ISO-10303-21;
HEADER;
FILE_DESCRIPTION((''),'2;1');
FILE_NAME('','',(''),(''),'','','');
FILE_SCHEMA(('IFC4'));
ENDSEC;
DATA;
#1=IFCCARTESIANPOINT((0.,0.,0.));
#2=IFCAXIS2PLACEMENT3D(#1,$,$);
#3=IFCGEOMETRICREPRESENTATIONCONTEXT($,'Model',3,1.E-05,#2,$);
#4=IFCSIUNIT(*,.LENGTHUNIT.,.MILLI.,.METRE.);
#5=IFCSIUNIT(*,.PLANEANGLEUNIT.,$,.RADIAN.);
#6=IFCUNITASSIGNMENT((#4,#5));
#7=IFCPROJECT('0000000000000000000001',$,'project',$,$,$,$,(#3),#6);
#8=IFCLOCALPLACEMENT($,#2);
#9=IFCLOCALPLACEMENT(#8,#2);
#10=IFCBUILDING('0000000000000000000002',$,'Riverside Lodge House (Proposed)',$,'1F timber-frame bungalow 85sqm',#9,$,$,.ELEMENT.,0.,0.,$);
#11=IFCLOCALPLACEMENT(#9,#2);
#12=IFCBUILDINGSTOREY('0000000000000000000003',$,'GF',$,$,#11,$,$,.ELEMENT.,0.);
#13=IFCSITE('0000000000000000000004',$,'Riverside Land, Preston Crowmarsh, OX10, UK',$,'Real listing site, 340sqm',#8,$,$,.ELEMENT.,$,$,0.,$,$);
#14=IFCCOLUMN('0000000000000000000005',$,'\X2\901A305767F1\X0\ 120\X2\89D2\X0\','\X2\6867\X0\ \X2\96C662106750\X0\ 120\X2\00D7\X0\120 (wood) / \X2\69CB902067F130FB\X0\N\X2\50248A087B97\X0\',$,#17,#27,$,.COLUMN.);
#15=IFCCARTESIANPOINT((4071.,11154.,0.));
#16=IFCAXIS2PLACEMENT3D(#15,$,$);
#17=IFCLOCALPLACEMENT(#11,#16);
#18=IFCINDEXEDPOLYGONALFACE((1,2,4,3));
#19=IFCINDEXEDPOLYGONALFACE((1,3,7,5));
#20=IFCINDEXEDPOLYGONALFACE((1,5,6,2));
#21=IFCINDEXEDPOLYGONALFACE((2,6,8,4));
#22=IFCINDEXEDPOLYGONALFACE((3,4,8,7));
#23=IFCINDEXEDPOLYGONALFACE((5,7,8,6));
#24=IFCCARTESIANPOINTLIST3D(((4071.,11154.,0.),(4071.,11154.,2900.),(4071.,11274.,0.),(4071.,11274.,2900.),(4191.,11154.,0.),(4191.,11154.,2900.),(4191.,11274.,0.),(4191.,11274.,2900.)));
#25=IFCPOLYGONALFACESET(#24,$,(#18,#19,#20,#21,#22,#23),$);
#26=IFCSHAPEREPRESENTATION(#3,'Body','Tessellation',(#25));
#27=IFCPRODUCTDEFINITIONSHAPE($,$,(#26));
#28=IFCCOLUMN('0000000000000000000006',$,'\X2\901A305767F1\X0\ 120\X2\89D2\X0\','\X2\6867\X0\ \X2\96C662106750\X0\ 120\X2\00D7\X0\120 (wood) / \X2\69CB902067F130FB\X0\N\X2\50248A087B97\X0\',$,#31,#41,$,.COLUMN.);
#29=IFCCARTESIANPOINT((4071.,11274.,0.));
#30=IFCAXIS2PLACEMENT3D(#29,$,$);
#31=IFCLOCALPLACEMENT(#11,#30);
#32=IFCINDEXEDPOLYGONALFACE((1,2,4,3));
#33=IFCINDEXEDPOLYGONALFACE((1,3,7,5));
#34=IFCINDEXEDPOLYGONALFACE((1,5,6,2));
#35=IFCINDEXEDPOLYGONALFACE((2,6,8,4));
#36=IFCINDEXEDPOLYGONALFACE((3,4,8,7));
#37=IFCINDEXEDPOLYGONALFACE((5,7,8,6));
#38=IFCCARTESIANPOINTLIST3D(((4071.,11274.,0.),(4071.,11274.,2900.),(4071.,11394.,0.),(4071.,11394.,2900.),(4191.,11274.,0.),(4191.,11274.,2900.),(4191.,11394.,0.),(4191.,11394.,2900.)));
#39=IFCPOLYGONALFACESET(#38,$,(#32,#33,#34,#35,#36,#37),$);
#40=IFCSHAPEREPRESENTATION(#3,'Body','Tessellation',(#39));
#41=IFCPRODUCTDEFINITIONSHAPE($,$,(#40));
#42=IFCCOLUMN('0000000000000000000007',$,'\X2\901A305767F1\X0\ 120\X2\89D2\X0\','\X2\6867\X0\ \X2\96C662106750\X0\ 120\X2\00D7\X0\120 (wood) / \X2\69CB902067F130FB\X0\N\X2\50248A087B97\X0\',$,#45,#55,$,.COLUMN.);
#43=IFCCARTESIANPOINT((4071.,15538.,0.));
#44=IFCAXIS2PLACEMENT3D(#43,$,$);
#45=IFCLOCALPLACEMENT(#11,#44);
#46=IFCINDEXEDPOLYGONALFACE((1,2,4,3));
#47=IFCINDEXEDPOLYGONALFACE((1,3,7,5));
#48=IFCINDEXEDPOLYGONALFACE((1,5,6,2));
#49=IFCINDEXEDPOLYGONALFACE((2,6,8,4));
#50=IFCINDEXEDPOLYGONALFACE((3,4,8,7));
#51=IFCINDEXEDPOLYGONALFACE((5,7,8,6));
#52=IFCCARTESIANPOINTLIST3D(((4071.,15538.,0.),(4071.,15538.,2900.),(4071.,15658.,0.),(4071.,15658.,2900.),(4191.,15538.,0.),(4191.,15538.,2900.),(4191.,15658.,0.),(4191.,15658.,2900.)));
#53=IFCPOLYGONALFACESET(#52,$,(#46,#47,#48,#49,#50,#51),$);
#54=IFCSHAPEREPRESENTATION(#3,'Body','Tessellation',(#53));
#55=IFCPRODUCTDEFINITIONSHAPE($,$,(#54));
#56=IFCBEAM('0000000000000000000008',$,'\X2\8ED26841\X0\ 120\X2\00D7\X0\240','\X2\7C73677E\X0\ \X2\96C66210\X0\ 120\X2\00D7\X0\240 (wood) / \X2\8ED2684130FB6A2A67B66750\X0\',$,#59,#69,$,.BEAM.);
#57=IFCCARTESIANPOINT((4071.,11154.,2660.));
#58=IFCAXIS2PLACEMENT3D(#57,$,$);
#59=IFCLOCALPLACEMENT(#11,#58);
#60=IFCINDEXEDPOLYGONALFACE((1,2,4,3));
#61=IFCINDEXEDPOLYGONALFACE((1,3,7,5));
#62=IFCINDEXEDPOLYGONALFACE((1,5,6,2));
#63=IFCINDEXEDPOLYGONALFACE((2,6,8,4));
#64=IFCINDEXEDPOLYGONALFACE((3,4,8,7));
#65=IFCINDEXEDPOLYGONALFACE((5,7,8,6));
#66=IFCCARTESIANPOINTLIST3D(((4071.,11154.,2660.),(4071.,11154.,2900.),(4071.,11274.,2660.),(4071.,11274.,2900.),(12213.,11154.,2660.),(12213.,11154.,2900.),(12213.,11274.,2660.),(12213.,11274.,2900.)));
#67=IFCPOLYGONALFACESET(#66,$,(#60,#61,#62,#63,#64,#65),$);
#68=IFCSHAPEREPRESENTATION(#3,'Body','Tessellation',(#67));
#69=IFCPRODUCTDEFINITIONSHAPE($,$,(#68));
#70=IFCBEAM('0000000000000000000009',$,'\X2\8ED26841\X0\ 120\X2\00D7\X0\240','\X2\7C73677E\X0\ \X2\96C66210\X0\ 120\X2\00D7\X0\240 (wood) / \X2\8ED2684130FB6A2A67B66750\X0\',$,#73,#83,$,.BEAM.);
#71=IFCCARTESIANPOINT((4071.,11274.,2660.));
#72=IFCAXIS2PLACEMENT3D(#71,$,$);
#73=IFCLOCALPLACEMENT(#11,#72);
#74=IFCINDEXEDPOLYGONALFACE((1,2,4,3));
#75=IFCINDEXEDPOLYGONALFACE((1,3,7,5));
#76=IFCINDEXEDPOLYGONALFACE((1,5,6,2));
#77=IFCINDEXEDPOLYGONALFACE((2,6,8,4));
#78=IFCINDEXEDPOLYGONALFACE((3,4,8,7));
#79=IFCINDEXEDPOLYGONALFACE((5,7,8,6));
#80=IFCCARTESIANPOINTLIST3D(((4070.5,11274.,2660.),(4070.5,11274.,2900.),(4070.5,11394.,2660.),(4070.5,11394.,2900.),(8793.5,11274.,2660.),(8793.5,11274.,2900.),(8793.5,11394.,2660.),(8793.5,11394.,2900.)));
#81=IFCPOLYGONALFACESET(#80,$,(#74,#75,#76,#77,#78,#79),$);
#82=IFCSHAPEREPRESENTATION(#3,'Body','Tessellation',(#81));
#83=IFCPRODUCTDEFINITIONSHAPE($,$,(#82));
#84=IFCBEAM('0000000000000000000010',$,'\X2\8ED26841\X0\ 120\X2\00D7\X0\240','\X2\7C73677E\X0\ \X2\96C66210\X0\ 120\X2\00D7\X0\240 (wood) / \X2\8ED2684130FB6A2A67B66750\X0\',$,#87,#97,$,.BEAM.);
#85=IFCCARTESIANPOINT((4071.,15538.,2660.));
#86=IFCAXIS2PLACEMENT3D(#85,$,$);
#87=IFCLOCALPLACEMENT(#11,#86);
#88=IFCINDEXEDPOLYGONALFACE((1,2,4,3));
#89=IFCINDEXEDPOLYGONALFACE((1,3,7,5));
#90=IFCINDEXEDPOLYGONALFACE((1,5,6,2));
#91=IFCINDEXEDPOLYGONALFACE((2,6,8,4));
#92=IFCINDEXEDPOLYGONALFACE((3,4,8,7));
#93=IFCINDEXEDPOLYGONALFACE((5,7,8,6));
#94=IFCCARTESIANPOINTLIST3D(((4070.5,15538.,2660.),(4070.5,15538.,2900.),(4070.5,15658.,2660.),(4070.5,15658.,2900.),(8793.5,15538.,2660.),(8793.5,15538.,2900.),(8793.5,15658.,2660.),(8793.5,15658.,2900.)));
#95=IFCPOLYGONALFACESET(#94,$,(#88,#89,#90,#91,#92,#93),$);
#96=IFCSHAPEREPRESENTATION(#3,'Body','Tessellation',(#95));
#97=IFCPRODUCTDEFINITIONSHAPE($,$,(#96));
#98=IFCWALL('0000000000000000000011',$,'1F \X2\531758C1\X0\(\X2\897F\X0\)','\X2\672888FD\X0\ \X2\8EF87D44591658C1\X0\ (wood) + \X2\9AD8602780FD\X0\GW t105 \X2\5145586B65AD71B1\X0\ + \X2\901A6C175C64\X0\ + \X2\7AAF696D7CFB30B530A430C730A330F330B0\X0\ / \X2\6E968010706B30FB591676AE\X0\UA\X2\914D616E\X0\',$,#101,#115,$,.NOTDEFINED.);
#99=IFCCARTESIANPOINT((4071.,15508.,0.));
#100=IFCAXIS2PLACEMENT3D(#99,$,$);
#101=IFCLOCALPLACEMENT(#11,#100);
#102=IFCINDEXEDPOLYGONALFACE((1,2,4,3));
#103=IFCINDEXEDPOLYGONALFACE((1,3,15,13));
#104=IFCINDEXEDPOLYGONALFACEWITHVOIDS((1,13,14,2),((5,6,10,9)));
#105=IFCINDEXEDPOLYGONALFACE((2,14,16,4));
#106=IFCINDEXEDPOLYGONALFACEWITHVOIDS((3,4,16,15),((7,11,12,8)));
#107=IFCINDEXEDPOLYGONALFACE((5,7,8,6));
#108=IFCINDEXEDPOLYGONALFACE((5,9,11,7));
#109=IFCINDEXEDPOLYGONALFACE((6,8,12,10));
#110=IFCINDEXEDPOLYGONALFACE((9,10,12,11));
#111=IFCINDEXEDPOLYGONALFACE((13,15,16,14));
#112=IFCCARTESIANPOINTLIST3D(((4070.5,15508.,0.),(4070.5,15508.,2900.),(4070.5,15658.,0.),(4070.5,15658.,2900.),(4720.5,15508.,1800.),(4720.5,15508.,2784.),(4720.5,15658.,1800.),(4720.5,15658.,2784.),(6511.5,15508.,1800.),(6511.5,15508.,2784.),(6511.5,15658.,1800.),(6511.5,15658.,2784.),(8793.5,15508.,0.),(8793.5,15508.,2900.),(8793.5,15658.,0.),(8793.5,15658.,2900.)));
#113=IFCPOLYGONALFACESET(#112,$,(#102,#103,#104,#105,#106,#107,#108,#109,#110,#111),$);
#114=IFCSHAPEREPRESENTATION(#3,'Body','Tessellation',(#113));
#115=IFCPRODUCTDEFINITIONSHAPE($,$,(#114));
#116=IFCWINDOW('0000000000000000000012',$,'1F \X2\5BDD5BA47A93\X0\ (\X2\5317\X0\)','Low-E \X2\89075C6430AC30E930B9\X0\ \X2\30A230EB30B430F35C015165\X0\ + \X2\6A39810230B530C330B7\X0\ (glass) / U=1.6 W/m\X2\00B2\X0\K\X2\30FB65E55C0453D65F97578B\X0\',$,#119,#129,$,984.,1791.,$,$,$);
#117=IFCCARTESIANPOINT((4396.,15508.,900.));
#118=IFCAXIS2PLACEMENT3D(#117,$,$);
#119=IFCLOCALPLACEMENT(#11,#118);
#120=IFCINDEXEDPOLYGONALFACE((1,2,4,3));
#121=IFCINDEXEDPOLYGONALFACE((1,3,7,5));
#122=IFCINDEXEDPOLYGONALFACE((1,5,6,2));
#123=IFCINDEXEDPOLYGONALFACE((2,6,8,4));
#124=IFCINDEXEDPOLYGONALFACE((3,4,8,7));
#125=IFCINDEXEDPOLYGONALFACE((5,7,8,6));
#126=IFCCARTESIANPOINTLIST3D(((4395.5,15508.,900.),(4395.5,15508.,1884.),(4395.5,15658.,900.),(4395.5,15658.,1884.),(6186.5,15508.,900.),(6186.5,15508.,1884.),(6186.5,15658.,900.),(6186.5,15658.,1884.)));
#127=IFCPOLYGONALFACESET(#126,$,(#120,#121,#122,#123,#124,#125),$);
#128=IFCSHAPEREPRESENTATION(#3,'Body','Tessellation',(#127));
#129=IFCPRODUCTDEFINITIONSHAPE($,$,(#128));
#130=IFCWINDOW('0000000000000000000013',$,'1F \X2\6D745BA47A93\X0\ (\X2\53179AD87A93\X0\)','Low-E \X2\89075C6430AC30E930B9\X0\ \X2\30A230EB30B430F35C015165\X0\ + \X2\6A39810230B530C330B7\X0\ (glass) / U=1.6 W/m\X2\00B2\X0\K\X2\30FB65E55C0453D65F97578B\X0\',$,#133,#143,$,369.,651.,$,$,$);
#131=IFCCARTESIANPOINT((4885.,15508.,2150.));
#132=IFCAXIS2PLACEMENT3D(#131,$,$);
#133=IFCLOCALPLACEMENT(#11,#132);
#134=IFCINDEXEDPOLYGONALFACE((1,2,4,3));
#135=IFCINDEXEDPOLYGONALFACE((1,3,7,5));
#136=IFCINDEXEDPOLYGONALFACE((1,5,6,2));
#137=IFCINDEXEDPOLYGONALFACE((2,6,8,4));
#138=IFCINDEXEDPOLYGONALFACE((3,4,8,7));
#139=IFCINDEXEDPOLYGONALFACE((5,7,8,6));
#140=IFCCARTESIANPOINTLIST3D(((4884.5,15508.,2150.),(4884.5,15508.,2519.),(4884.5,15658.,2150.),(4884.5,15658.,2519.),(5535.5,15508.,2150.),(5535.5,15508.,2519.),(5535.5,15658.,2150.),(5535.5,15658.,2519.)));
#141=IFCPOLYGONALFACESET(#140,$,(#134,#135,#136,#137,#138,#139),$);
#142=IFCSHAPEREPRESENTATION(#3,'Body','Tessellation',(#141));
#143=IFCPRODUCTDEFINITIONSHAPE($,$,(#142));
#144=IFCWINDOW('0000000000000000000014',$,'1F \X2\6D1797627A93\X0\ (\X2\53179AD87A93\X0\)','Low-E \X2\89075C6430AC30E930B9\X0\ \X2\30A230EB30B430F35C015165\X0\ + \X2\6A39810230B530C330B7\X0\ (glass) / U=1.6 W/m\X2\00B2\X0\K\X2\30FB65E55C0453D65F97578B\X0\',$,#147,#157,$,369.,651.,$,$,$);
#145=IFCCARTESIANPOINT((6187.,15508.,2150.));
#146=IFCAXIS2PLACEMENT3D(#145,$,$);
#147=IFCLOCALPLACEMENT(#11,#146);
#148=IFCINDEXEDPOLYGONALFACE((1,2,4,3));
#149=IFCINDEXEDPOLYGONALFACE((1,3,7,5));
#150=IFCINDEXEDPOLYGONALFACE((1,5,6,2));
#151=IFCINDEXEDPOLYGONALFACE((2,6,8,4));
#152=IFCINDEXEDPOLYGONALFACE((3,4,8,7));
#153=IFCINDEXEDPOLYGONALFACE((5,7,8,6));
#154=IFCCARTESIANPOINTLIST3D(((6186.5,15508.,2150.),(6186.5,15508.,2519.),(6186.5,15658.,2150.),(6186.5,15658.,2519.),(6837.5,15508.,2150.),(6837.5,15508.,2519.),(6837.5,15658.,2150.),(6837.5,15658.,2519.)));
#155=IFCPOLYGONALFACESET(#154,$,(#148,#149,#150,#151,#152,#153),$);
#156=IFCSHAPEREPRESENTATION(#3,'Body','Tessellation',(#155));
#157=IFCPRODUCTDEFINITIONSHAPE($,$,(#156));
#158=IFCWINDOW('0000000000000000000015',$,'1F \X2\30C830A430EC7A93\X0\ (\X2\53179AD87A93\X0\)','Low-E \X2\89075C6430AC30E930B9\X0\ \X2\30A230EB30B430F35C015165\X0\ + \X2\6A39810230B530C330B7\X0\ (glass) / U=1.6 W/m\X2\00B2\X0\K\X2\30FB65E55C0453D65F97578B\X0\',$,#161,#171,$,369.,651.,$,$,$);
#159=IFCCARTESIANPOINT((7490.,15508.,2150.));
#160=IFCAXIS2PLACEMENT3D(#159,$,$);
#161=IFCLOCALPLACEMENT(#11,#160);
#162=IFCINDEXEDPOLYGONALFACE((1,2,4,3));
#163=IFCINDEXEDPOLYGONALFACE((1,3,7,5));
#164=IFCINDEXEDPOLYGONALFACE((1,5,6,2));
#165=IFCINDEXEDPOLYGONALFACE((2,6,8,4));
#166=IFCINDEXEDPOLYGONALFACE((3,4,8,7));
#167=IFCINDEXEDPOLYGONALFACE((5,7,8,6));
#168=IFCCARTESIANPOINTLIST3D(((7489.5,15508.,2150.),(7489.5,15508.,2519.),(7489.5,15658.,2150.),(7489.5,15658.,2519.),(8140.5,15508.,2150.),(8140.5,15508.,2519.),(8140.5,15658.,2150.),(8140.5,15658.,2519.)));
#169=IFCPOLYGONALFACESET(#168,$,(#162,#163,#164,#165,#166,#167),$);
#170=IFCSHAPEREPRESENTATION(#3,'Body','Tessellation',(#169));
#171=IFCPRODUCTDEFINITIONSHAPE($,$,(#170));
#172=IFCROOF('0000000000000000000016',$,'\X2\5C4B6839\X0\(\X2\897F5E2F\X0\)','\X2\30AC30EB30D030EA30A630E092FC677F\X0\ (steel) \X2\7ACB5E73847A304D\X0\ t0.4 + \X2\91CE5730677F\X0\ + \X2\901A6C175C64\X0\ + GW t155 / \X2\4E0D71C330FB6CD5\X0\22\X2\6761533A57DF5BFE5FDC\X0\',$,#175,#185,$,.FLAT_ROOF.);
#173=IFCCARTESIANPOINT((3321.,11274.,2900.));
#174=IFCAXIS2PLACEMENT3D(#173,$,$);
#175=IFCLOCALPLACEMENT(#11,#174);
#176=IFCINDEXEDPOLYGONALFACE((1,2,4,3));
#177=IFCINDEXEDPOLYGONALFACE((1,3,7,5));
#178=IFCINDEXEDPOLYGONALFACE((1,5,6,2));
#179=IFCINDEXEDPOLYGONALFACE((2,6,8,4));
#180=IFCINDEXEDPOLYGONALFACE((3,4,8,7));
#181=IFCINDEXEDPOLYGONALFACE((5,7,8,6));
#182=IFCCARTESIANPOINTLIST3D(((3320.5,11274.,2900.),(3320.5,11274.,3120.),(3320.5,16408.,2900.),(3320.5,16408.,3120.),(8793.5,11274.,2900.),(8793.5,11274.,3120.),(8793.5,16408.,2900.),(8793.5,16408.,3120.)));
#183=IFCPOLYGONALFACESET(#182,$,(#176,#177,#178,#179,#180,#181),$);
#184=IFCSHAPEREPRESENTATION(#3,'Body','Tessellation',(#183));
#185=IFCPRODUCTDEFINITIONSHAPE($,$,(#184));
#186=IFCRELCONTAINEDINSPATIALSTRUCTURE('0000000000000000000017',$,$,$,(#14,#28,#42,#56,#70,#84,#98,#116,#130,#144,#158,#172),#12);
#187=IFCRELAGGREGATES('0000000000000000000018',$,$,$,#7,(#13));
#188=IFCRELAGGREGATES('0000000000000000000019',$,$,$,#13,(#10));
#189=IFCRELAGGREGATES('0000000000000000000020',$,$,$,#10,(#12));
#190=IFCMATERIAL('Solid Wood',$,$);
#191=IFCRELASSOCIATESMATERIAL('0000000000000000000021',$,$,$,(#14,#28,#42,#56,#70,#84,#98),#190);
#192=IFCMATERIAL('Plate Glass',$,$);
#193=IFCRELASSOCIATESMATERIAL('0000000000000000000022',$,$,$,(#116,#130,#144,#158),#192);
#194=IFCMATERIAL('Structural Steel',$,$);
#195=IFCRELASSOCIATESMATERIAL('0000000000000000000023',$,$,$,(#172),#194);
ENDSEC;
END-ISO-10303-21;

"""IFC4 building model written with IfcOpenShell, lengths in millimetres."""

from ifc_helpers import new_model, si_unit, frame, frame_2d, origin, place, context, project, spatial, rectangle, extrude, material, element, fill, save


model = new_model("IFC4")

# Units and contexts
model_context = context("Model", 3, precision=1e-05, world=origin())
ifc_project = project(units=[si_unit("LENGTHUNIT", "METRE", prefix="MILLI"), si_unit("PLANEANGLEUNIT", "RADIAN")], contexts=[model_context])

# Site, building, storey
site_placement = place(None, origin())
site = spatial("IfcSite", under=ifc_project, at=site_placement, Name="Riverside Land, Preston Crowmarsh, OX10, UK", ObjectType="Real listing site, 340sqm", CompositionType="ELEMENT", RefElevation=0.0)
building_placement = place(site_placement, origin())
building = spatial("IfcBuilding", under=site, at=building_placement, Name="Riverside Lodge House (Proposed)", ObjectType="1F timber-frame bungalow 85sqm", CompositionType="ELEMENT", ElevationOfRefHeight=0.0, ElevationOfTerrain=0.0)
storey_placement = place(building_placement, origin())
storey = spatial("IfcBuildingStorey", under=building, at=storey_placement, Name="GF", CompositionType="ELEMENT", Elevation=0.0)

# Columns
ifc_material_1 = material(Name="Solid Wood")
column_1_placement = place(storey_placement, frame((4071.0, 11154.0, 0.0)))
element("IfcColumn", 1, at=column_1_placement, inside=storey, material=ifc_material_1, Name="通し柱 120角", Description="桧 集成材 120×120 (wood) / 構造柱・N値計算", PredefinedType="COLUMN", context=model_context, shape_type="SweptSolid", body=[
    extrude(rectangle(XDim=120.0, YDim=120.0, at=frame_2d((60.0, 60.0))), frame((4071.0, 11154.0, 0.0)), (0.0, 0.0, 1.0), 2900.0),
])
column_2_placement = place(storey_placement, frame((4071.0, 11274.0, 0.0)))
element("IfcColumn", 2, at=column_2_placement, inside=storey, material=ifc_material_1, Name="通し柱 120角", Description="桧 集成材 120×120 (wood) / 構造柱・N値計算", PredefinedType="COLUMN", context=model_context, shape_type="SweptSolid", body=[
    extrude(rectangle(XDim=120.0, YDim=120.0, at=frame_2d((60.0, 60.0))), frame((4071.0, 11274.0, 0.0)), (0.0, 0.0, 1.0), 2900.0),
])
column_3_placement = place(storey_placement, frame((4071.0, 15538.0, 0.0)))
element("IfcColumn", 3, at=column_3_placement, inside=storey, material=ifc_material_1, Name="通し柱 120角", Description="桧 集成材 120×120 (wood) / 構造柱・N値計算", PredefinedType="COLUMN", context=model_context, shape_type="SweptSolid", body=[
    extrude(rectangle(XDim=120.0, YDim=120.0, at=frame_2d((60.0, 60.0))), frame((4071.0, 15538.0, 0.0)), (0.0, 0.0, 1.0), 2900.0),
])

# Beams
beam_1_placement = place(storey_placement, frame((4071.0, 11154.0, 2660.0)))
element("IfcBeam", 4, at=beam_1_placement, inside=storey, material=ifc_material_1, Name="軒桁 120×240", Description="米松 集成 120×240 (wood) / 軒桁・横架材", PredefinedType="BEAM", context=model_context, shape_type="SweptSolid", body=[
    extrude(rectangle(XDim=8142.0, YDim=120.0, at=frame_2d((4071.0, 60.0))), frame((4071.0, 11154.0, 2660.0)), (0.0, 0.0, 1.0), 240.0),
])
beam_2_placement = place(storey_placement, frame((4071.0, 11274.0, 2660.0)))
element("IfcBeam", 5, at=beam_2_placement, inside=storey, material=ifc_material_1, Name="軒桁 120×240", Description="米松 集成 120×240 (wood) / 軒桁・横架材", PredefinedType="BEAM", context=model_context, shape_type="SweptSolid", body=[
    extrude(rectangle(XDim=4723.0, YDim=120.0, at=frame_2d((2361.0, 60.0))), frame((4071.0, 11274.0, 2660.0)), (0.0, 0.0, 1.0), 240.0),
])
beam_3_placement = place(storey_placement, frame((4071.0, 15538.0, 2660.0)))
element("IfcBeam", 6, at=beam_3_placement, inside=storey, material=ifc_material_1, Name="軒桁 120×240", Description="米松 集成 120×240 (wood) / 軒桁・横架材", PredefinedType="BEAM", context=model_context, shape_type="SweptSolid", body=[
    extrude(rectangle(XDim=4723.0, YDim=120.0, at=frame_2d((2361.0, 60.0))), frame((4071.0, 15538.0, 2660.0)), (0.0, 0.0, 1.0), 240.0),
])

# Wall, openings, windows
wall_1_placement = place(storey_placement, frame((4071.0, 15508.0, 0.0)))
wall_1 = element("IfcWall", 7, at=wall_1_placement, inside=storey, material=ifc_material_1, Name="1F 北壁(西)", Description="木製 軸組外壁 (wood) + 高性能GW t105 充填断熱 + 通気層 + 窯業系サイディング / 準耐火・外皮UA配慮", PredefinedType="NOTDEFINED", context=model_context, shape_type="SweptSolid", body=[
    extrude(rectangle(XDim=4723.0, YDim=150.0, at=frame_2d((2361.0, 75.0))), frame((4071.0, 15508.0, 0.0)), (0.0, 0.0, 1.0), 2900.0),
])
opening_1_placement = place(storey_placement, frame((4396.0, 15508.0, 900.0)))
opening_1 = element("IfcOpeningElement", 8, at=opening_1_placement, cuts=wall_1, PredefinedType="NOTDEFINED", context=model_context, shape_type="SweptSolid", body=[
    extrude(rectangle(XDim=1791.0, YDim=150.0, at=frame_2d((895.0, 75.0))), frame((4396.0, 15508.0, 900.0)), (0.0, 0.0, 1.0), 984.0),
])
opening_2_placement = place(storey_placement, frame((4885.0, 15508.0, 2150.0)))
opening_2 = element("IfcOpeningElement", 9, at=opening_2_placement, cuts=wall_1, PredefinedType="NOTDEFINED", context=model_context, shape_type="SweptSolid", body=[
    extrude(rectangle(XDim=651.0, YDim=150.0, at=frame_2d((325.0, 75.0))), frame((4885.0, 15508.0, 2150.0)), (0.0, 0.0, 1.0), 369.0),
])
opening_3_placement = place(storey_placement, frame((6187.0, 15508.0, 2150.0)))
opening_3 = element("IfcOpeningElement", 10, at=opening_3_placement, cuts=wall_1, PredefinedType="NOTDEFINED", context=model_context, shape_type="SweptSolid", body=[
    extrude(rectangle(XDim=651.0, YDim=150.0, at=frame_2d((325.0, 75.0))), frame((6187.0, 15508.0, 2150.0)), (0.0, 0.0, 1.0), 369.0),
])
opening_4_placement = place(storey_placement, frame((7490.0, 15508.0, 2150.0)))
opening_4 = element("IfcOpeningElement", 11, at=opening_4_placement, cuts=wall_1, PredefinedType="NOTDEFINED", context=model_context, shape_type="SweptSolid", body=[
    extrude(rectangle(XDim=651.0, YDim=150.0, at=frame_2d((325.0, 75.0))), frame((7490.0, 15508.0, 2150.0)), (0.0, 0.0, 1.0), 369.0),
])
ifc_material_2 = material(Name="Plate Glass")
window_1_placement = place(storey_placement, frame((4396.0, 15508.0, 900.0)))
window_1 = element("IfcWindow", 12, at=window_1_placement, inside=storey, material=ifc_material_2, Name="1F 寝室窓 (北)", Description="Low-E 複層ガラス アルゴン封入 + 樹脂サッシ (glass) / U=1.6 W/m²K・日射取得型", OverallHeight=984.0, OverallWidth=1791.0, context=model_context, shape_type="SweptSolid", body=[
    extrude(rectangle(XDim=1791.0, YDim=150.0, at=frame_2d((895.0, 75.0))), frame((4396.0, 15508.0, 900.0)), (0.0, 0.0, 1.0), 984.0),
])
fill(opening_1, window_1)
window_2_placement = place(storey_placement, frame((4885.0, 15508.0, 2150.0)))
window_2 = element("IfcWindow", 13, at=window_2_placement, inside=storey, material=ifc_material_2, Name="1F 浴室窓 (北高窓)", Description="Low-E 複層ガラス アルゴン封入 + 樹脂サッシ (glass) / U=1.6 W/m²K・日射取得型", OverallHeight=369.0, OverallWidth=651.0, context=model_context, shape_type="SweptSolid", body=[
    extrude(rectangle(XDim=651.0, YDim=150.0, at=frame_2d((325.0, 75.0))), frame((4885.0, 15508.0, 2150.0)), (0.0, 0.0, 1.0), 369.0),
])
fill(opening_2, window_2)
window_3_placement = place(storey_placement, frame((6187.0, 15508.0, 2150.0)))
window_3 = element("IfcWindow", 14, at=window_3_placement, inside=storey, material=ifc_material_2, Name="1F 洗面窓 (北高窓)", Description="Low-E 複層ガラス アルゴン封入 + 樹脂サッシ (glass) / U=1.6 W/m²K・日射取得型", OverallHeight=369.0, OverallWidth=651.0, context=model_context, shape_type="SweptSolid", body=[
    extrude(rectangle(XDim=651.0, YDim=150.0, at=frame_2d((325.0, 75.0))), frame((6187.0, 15508.0, 2150.0)), (0.0, 0.0, 1.0), 369.0),
])
fill(opening_3, window_3)
window_4_placement = place(storey_placement, frame((7490.0, 15508.0, 2150.0)))
window_4 = element("IfcWindow", 15, at=window_4_placement, inside=storey, material=ifc_material_2, Name="1F トイレ窓 (北高窓)", Description="Low-E 複層ガラス アルゴン封入 + 樹脂サッシ (glass) / U=1.6 W/m²K・日射取得型", OverallHeight=369.0, OverallWidth=651.0, context=model_context, shape_type="SweptSolid", body=[
    extrude(rectangle(XDim=651.0, YDim=150.0, at=frame_2d((325.0, 75.0))), frame((7490.0, 15508.0, 2150.0)), (0.0, 0.0, 1.0), 369.0),
])
fill(opening_4, window_4)

# Roof
ifc_material_3 = material(Name="Structural Steel")
roof_placement = place(storey_placement, frame((3321.0, 11274.0, 2900.0)))
element("IfcRoof", 16, at=roof_placement, inside=storey, material=ifc_material_3, Name="屋根(西帯)", Description="ガルバリウム鋼板 (steel) 立平葺き t0.4 + 野地板 + 通気層 + GW t155 / 不燃・法22条区域対応", PredefinedType="FLAT_ROOF", context=model_context, shape_type="SweptSolid", body=[
    extrude(rectangle(XDim=5473.0, YDim=5134.0, at=frame_2d((2736.0, 2567.0))), frame((3321.0, 11274.0, 2900.0)), (0.0, 0.0, 1.0), 220.0),
])

save(model, "model.ifc")
